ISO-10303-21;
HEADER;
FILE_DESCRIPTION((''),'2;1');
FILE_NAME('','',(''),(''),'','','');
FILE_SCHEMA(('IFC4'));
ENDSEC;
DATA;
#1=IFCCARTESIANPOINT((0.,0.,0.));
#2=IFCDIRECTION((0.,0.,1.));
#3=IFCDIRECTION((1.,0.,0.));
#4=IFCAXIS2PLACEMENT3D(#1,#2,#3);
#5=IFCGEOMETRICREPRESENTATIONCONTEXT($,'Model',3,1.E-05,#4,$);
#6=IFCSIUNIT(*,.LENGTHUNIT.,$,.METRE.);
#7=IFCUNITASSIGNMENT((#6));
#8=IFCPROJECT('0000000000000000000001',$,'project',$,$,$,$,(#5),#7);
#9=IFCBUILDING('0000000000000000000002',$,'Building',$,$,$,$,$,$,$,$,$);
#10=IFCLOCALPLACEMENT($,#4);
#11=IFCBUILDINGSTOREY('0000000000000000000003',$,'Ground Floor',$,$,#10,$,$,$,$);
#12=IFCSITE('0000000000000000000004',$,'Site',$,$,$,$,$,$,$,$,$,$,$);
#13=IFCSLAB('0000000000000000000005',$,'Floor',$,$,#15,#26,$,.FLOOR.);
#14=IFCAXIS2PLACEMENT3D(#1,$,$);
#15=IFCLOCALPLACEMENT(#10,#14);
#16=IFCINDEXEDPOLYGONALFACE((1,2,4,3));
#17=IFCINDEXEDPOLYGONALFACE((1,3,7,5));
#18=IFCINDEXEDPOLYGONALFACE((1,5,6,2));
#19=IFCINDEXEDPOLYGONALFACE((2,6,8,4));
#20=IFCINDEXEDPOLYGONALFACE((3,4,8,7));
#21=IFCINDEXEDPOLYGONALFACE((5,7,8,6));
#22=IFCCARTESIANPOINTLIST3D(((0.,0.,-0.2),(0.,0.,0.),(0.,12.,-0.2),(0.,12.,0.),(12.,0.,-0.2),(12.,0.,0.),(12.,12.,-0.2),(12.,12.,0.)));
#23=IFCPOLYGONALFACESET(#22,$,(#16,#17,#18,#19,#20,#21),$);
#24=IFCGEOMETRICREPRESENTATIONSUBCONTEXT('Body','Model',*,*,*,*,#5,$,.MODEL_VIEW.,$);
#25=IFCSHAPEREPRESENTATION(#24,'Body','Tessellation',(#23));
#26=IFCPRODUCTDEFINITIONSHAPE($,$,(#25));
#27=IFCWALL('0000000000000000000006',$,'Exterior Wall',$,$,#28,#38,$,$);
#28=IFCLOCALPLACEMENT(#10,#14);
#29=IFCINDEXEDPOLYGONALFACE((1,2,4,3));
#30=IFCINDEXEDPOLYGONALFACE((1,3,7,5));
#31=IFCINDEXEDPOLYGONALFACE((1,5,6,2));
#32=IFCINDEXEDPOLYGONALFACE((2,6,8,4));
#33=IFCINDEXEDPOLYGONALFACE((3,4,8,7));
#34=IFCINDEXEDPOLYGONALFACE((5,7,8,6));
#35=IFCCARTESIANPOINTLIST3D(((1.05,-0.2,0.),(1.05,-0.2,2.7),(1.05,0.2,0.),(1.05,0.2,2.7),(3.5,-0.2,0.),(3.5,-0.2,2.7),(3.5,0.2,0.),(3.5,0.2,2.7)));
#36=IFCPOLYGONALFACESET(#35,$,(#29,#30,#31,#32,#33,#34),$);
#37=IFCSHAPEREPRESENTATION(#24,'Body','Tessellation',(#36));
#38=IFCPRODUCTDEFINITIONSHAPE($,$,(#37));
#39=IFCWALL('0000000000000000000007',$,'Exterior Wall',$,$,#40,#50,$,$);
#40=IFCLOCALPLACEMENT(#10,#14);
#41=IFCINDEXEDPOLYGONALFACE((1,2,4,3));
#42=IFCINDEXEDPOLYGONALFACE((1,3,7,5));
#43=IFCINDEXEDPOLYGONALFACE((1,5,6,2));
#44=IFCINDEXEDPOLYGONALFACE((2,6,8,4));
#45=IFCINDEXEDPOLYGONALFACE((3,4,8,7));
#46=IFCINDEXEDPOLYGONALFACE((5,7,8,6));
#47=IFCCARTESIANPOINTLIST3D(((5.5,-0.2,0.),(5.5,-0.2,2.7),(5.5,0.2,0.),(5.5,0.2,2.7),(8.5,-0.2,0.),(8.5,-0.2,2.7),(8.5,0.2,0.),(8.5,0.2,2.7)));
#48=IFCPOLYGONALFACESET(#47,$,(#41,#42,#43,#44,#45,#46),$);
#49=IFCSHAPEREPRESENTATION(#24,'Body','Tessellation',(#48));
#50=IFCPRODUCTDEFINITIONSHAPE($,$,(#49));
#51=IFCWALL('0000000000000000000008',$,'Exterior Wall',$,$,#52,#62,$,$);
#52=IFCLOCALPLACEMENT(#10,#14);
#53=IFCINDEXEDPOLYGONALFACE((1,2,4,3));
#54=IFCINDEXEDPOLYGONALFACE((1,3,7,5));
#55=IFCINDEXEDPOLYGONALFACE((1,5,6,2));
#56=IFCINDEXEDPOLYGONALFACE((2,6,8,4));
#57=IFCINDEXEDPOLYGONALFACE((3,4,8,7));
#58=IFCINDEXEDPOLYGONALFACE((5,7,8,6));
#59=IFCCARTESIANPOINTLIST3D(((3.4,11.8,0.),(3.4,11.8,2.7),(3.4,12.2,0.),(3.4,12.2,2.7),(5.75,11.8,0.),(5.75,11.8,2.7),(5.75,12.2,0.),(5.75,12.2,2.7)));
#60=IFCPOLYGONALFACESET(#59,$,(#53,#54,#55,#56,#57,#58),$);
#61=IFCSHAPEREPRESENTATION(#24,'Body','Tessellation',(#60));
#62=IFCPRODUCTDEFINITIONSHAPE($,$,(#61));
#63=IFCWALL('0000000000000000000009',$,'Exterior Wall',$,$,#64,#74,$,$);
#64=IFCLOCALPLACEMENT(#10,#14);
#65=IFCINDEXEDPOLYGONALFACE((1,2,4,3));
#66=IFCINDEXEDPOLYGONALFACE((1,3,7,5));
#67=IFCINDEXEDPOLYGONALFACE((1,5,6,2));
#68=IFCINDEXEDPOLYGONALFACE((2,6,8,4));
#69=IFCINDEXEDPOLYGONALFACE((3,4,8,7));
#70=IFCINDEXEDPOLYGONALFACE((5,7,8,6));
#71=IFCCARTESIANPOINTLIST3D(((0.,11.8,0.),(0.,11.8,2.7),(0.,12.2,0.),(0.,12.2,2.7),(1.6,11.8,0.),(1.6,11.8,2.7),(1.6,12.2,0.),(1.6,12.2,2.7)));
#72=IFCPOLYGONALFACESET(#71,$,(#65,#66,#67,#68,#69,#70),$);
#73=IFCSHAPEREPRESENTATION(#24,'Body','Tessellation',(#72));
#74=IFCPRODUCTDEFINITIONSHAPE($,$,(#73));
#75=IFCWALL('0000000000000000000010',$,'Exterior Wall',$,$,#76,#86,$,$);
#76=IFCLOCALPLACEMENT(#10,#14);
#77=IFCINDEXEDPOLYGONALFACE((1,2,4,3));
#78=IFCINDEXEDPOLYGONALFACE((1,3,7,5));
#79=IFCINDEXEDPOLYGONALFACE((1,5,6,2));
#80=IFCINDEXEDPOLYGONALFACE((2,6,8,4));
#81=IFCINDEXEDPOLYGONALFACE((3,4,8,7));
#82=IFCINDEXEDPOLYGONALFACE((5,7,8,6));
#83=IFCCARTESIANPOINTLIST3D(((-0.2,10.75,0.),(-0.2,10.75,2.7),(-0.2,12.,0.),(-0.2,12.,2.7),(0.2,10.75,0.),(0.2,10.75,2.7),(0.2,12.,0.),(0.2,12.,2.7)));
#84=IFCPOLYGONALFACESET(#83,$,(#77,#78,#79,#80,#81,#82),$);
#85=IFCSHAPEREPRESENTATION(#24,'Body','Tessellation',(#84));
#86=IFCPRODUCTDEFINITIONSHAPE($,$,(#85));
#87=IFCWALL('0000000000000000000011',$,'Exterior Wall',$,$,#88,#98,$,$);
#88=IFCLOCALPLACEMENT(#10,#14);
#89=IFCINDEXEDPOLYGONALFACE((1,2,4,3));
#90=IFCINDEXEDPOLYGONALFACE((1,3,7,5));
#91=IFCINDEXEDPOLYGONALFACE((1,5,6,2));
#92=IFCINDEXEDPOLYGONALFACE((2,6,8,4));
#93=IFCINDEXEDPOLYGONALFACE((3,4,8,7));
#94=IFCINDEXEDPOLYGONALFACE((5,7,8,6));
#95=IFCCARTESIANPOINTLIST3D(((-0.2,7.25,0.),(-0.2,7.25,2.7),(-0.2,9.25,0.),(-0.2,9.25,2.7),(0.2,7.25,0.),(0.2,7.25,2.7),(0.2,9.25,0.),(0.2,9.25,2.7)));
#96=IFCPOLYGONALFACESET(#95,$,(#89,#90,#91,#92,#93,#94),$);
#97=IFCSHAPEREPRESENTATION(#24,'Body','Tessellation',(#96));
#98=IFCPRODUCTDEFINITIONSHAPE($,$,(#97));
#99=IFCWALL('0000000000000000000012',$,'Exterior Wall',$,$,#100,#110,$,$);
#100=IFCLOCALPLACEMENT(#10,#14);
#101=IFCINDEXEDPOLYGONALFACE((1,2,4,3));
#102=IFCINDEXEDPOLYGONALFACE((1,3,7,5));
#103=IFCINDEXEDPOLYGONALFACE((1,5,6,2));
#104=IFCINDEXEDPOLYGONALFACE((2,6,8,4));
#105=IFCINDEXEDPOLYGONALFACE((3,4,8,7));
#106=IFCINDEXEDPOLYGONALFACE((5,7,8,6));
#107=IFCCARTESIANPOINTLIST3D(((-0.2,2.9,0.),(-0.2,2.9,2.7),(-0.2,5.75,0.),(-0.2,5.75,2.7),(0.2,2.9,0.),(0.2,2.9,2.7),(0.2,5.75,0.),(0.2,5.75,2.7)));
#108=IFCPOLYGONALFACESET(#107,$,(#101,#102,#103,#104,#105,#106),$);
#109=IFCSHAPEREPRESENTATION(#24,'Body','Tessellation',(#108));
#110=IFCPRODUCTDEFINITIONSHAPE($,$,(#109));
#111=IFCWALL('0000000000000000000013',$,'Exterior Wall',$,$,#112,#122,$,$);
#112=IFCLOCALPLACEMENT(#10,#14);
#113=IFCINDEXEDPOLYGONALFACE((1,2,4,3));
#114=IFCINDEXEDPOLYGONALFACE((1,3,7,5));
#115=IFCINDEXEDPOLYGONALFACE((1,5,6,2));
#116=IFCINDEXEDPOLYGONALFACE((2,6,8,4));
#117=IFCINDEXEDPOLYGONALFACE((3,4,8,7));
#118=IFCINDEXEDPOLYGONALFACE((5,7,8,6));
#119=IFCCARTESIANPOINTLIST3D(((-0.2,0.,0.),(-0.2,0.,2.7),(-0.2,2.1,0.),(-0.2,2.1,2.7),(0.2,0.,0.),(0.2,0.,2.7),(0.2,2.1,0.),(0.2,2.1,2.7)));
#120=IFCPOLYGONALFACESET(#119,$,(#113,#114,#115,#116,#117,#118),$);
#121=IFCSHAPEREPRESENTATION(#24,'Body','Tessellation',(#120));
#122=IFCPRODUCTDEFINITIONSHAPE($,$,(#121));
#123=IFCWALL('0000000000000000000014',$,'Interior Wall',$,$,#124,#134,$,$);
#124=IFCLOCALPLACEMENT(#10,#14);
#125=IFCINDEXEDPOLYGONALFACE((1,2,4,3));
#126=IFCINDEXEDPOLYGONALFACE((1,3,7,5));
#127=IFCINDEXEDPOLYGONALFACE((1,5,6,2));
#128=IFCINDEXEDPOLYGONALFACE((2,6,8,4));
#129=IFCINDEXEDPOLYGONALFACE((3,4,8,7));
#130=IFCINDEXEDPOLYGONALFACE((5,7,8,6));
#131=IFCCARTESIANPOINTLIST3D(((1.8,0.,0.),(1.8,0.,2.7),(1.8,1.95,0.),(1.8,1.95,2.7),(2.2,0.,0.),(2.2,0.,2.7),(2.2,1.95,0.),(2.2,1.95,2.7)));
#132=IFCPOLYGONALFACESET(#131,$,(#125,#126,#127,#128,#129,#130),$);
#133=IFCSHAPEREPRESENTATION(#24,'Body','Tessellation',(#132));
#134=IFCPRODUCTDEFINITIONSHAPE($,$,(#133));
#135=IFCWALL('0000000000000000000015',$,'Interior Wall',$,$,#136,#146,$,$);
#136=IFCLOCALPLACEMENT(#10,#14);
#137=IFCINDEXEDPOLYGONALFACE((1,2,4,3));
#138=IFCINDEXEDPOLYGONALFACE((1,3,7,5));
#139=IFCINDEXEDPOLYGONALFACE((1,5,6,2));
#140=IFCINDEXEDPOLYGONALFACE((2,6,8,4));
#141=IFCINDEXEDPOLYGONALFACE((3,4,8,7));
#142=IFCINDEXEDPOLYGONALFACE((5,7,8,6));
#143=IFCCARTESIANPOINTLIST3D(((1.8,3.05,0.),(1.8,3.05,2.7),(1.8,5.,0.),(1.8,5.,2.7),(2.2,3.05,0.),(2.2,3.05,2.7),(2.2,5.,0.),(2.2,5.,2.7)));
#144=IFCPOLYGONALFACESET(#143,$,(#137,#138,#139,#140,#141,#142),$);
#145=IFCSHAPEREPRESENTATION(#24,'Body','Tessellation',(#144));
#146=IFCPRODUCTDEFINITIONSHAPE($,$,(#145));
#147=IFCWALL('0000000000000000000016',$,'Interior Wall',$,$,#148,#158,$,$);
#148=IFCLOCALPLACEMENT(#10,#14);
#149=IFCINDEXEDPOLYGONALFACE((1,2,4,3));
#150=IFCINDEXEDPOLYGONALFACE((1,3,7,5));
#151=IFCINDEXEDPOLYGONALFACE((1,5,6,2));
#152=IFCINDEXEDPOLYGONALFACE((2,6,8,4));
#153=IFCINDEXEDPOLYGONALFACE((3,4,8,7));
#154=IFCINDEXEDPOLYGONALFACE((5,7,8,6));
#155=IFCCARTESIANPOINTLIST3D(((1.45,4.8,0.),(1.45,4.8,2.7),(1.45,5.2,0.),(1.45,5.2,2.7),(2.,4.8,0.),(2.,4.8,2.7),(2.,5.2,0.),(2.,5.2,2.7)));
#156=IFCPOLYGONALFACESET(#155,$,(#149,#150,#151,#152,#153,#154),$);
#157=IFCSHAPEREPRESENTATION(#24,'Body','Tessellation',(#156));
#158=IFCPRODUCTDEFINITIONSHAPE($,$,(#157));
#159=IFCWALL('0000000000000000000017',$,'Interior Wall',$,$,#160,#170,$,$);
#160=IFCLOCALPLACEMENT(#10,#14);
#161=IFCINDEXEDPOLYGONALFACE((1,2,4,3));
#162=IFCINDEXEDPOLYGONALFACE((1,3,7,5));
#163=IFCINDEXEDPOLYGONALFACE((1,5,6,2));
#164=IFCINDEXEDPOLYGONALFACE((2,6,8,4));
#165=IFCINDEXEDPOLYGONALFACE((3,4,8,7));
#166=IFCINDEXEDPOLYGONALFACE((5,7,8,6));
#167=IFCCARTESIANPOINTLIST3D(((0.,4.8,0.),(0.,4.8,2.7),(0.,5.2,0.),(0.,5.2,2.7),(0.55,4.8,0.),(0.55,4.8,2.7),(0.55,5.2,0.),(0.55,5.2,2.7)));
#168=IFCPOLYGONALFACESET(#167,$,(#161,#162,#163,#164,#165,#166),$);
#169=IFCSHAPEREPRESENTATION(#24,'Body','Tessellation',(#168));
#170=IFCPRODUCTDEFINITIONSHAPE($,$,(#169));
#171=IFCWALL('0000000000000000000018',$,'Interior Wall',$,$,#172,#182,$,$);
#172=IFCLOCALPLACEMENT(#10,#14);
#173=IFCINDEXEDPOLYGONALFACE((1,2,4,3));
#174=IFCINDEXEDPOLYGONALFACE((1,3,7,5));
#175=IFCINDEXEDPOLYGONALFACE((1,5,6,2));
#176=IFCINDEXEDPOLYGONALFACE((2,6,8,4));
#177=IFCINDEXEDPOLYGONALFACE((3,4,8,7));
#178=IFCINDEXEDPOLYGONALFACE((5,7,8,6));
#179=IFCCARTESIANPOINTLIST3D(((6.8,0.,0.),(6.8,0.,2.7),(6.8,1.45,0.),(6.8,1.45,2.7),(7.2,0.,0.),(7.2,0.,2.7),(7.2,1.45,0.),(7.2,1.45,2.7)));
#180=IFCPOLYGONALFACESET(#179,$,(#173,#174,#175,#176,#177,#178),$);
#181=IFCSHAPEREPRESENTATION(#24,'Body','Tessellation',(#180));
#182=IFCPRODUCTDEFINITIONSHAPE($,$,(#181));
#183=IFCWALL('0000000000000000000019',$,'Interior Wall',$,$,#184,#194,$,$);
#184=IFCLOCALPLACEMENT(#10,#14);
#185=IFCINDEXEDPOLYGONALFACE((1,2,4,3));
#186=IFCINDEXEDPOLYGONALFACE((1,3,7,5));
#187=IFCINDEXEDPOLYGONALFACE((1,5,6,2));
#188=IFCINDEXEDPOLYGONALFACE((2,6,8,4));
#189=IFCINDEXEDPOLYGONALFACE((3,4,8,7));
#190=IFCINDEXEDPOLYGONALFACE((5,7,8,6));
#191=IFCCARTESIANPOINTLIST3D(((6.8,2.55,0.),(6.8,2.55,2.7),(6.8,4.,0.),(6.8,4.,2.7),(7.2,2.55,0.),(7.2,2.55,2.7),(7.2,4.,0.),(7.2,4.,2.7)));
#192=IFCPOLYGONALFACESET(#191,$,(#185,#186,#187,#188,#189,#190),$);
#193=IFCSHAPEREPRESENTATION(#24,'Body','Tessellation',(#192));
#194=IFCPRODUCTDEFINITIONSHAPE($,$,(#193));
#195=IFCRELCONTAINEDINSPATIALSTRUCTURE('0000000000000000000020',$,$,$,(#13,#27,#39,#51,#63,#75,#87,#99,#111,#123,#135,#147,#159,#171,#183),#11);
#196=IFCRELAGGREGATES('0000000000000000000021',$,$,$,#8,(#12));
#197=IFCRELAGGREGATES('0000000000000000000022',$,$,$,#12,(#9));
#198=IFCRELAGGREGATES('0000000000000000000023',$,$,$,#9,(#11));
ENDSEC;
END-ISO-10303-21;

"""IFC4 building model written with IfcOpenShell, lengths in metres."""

from ifc_helpers import new_model, si_unit, frame, origin_with_axes, place, context, subcontext, project, spatial, indexed_curve, outline, extrude, element, save


model = new_model("IFC4")

# Units and contexts
model_context = context("Model", 3, precision=1e-05, world=origin_with_axes())
body_context = subcontext(model_context, "Body", "Model", "MODEL_VIEW")
ifc_project = project(units=[si_unit("LENGTHUNIT", "METRE")], contexts=[model_context])

# Site, building, storey
site = spatial("IfcSite", under=ifc_project, Name="Site")
building = spatial("IfcBuilding", under=site, Name="Building")
storey_placement = place(None, origin_with_axes())
storey = spatial("IfcBuildingStorey", under=building, at=storey_placement, Name="Ground Floor")

# Slab
slab_placement = place(storey_placement, frame((0.0, 0.0, -0.2), z_axis=(0.0, 0.0, 1.0), x_axis=(1.0, 0.0, 0.0)))
element("IfcSlab", 1, at=slab_placement, inside=storey, Name="Floor", PredefinedType="FLOOR", context=body_context, shape_type="SweptSolid", body=[
    extrude(outline(indexed_curve([(0.0, 0.0), (12.0, 0.0), (12.0, 12.0), (0.0, 12.0)])), None, (0.0, 0.0, 1.0), 0.2),
])

# Walls
wall_1_placement = place(storey_placement, frame((1.05, 0.0, 0.0), z_axis=(0.0, 0.0, 1.0), x_axis=(1.0, 0.0, 0.0)))
element("IfcWall", 2, at=wall_1_placement, inside=storey, Name="Exterior Wall", context=body_context, shape_type="SweptSolid", body=[
    extrude(outline(indexed_curve([(0.0, 0.0), (0.0, 0.4), (2.45, 0.4), (2.45, 0.0), (0.0, 0.0)], self_intersect=False)), frame((0.0, -0.2, 0.0), z_axis=(0.0, 0.0, 1.0), x_axis=(1.0, 0.0, 0.0)), (0.0, 0.0, 1.0), 2.7),
])
wall_2_placement = place(storey_placement, frame((5.5, 0.0, 0.0), z_axis=(0.0, 0.0, 1.0), x_axis=(1.0, 0.0, 0.0)))
element("IfcWall", 3, at=wall_2_placement, inside=storey, Name="Exterior Wall", context=body_context, shape_type="SweptSolid", body=[
    extrude(outline(indexed_curve([(0.0, 0.0), (0.0, 0.4), (3.0, 0.4), (3.0, 0.0), (0.0, 0.0)], self_intersect=False)), frame((0.0, -0.2, 0.0), z_axis=(0.0, 0.0, 1.0), x_axis=(1.0, 0.0, 0.0)), (0.0, 0.0, 1.0), 2.7),
])
wall_3_placement = place(storey_placement, frame((5.75, 12.0, 0.0), z_axis=(0.0, 0.0, 1.0), x_axis=(-1.0, 0.0, 0.0)))
element("IfcWall", 4, at=wall_3_placement, inside=storey, Name="Exterior Wall", context=body_context, shape_type="SweptSolid", body=[
    extrude(outline(indexed_curve([(0.0, 0.0), (0.0, 0.4), (2.35, 0.4), (2.35, 0.0), (0.0, 0.0)], self_intersect=False)), frame((0.0, -0.2, 0.0), z_axis=(0.0, 0.0, 1.0), x_axis=(1.0, 0.0, 0.0)), (0.0, 0.0, 1.0), 2.7),
])
wall_4_placement = place(storey_placement, frame((1.6, 12.0, 0.0), z_axis=(0.0, 0.0, 1.0), x_axis=(-1.0, 0.0, 0.0)))
element("IfcWall", 5, at=wall_4_placement, inside=storey, Name="Exterior Wall", context=body_context, shape_type="SweptSolid", body=[
    extrude(outline(indexed_curve([(0.0, 0.0), (0.0, 0.4), (1.6, 0.4), (1.6, 0.0), (0.0, 0.0)], self_intersect=False)), frame((0.0, -0.2, 0.0), z_axis=(0.0, 0.0, 1.0), x_axis=(1.0, 0.0, 0.0)), (0.0, 0.0, 1.0), 2.7),
])
wall_5_placement = place(storey_placement, frame((0.0, 12.0, 0.0), z_axis=(0.0, 0.0, 1.0), x_axis=(0.0, -1.0, 0.0)))
element("IfcWall", 6, at=wall_5_placement, inside=storey, Name="Exterior Wall", context=body_context, shape_type="SweptSolid", body=[
    extrude(outline(indexed_curve([(0.0, 0.0), (0.0, 0.4), (1.25, 0.4), (1.25, 0.0), (0.0, 0.0)], self_intersect=False)), frame((0.0, -0.2, 0.0), z_axis=(0.0, 0.0, 1.0), x_axis=(1.0, 0.0, 0.0)), (0.0, 0.0, 1.0), 2.7),
])
wall_6_placement = place(storey_placement, frame((0.0, 9.25, 0.0), z_axis=(0.0, 0.0, 1.0), x_axis=(0.0, -1.0, 0.0)))
element("IfcWall", 7, at=wall_6_placement, inside=storey, Name="Exterior Wall", context=body_context, shape_type="SweptSolid", body=[
    extrude(outline(indexed_curve([(0.0, 0.0), (0.0, 0.4), (2.0, 0.4), (2.0, 0.0), (0.0, 0.0)], self_intersect=False)), frame((0.0, -0.2, 0.0), z_axis=(0.0, 0.0, 1.0), x_axis=(1.0, 0.0, 0.0)), (0.0, 0.0, 1.0), 2.7),
])
wall_7_placement = place(storey_placement, frame((0.0, 5.75, 0.0), z_axis=(0.0, 0.0, 1.0), x_axis=(0.0, -1.0, 0.0)))
element("IfcWall", 8, at=wall_7_placement, inside=storey, Name="Exterior Wall", context=body_context, shape_type="SweptSolid", body=[
    extrude(outline(indexed_curve([(0.0, 0.0), (0.0, 0.4), (2.85, 0.4), (2.85, 0.0), (0.0, 0.0)], self_intersect=False)), frame((0.0, -0.2, 0.0), z_axis=(0.0, 0.0, 1.0), x_axis=(1.0, 0.0, 0.0)), (0.0, 0.0, 1.0), 2.7),
])
wall_8_placement = place(storey_placement, frame((0.0, 2.1, 0.0), z_axis=(0.0, 0.0, 1.0), x_axis=(0.0, -1.0, 0.0)))
element("IfcWall", 9, at=wall_8_placement, inside=storey, Name="Exterior Wall", context=body_context, shape_type="SweptSolid", body=[
    extrude(outline(indexed_curve([(0.0, 0.0), (0.0, 0.4), (2.1, 0.4), (2.1, 0.0), (0.0, 0.0)], self_intersect=False)), frame((0.0, -0.2, 0.0), z_axis=(0.0, 0.0, 1.0), x_axis=(1.0, 0.0, 0.0)), (0.0, 0.0, 1.0), 2.7),
])
wall_9_placement = place(storey_placement, frame((2.0, 0.0, 0.0), z_axis=(0.0, 0.0, 1.0), x_axis=(0.0, 1.0, 0.0)))
element("IfcWall", 10, at=wall_9_placement, inside=storey, Name="Interior Wall", context=body_context, shape_type="SweptSolid", body=[
    extrude(outline(indexed_curve([(0.0, 0.0), (0.0, 0.4), (1.95, 0.4), (1.95, 0.0), (0.0, 0.0)], self_intersect=False)), frame((0.0, -0.2, 0.0), z_axis=(0.0, 0.0, 1.0), x_axis=(1.0, 0.0, 0.0)), (0.0, 0.0, 1.0), 2.7),
])
wall_10_placement = place(storey_placement, frame((2.0, 3.05, 0.0), z_axis=(0.0, 0.0, 1.0), x_axis=(0.0, 1.0, 0.0)))
element("IfcWall", 11, at=wall_10_placement, inside=storey, Name="Interior Wall", context=body_context, shape_type="SweptSolid", body=[
    extrude(outline(indexed_curve([(0.0, 0.0), (0.0, 0.4), (1.95, 0.4), (1.95, 0.0), (0.0, 0.0)], self_intersect=False)), frame((0.0, -0.2, 0.0), z_axis=(0.0, 0.0, 1.0), x_axis=(1.0, 0.0, 0.0)), (0.0, 0.0, 1.0), 2.7),
])
for number, where, z_axis, x_axis, name in (
    (12, (2.0, 5.0, 0.0), (0.0, 0.0, 1.0), (-1.0, 0.0, 0.0), "Interior Wall"),
    (13, (0.55, 5.0, 0.0), (0.0, 0.0, 1.0), (-1.0, 0.0, 0.0), "Interior Wall"),
):
    element("IfcWall", number, at=place(storey_placement, frame(where, z_axis=z_axis, x_axis=x_axis)), inside=storey, Name=name, context=body_context, shape_type="SweptSolid", body=[
        extrude(outline(indexed_curve([(0.0, 0.0), (0.0, 0.4), (0.55, 0.4), (0.55, 0.0), (0.0, 0.0)], self_intersect=False)), frame((0.0, -0.2, 0.0), z_axis=(0.0, 0.0, 1.0), x_axis=(1.0, 0.0, 0.0)), (0.0, 0.0, 1.0), 2.7),
    ])
wall_11_placement = place(storey_placement, frame((7.0, 0.0, 0.0), z_axis=(0.0, 0.0, 1.0), x_axis=(0.0, 1.0, 0.0)))
element("IfcWall", 14, at=wall_11_placement, inside=storey, Name="Interior Wall", context=body_context, shape_type="SweptSolid", body=[
    extrude(outline(indexed_curve([(0.0, 0.0), (0.0, 0.4), (1.45, 0.4), (1.45, 0.0), (0.0, 0.0)], self_intersect=False)), frame((0.0, -0.2, 0.0), z_axis=(0.0, 0.0, 1.0), x_axis=(1.0, 0.0, 0.0)), (0.0, 0.0, 1.0), 2.7),
])
wall_12_placement = place(storey_placement, frame((7.0, 2.55, 0.0), z_axis=(0.0, 0.0, 1.0), x_axis=(0.0, 1.0, 0.0)))
element("IfcWall", 15, at=wall_12_placement, inside=storey, Name="Interior Wall", context=body_context, shape_type="SweptSolid", body=[
    extrude(outline(indexed_curve([(0.0, 0.0), (0.0, 0.4), (1.45, 0.4), (1.45, 0.0), (0.0, 0.0)], self_intersect=False)), frame((0.0, -0.2, 0.0), z_axis=(0.0, 0.0, 1.0), x_axis=(1.0, 0.0, 0.0)), (0.0, 0.0, 1.0), 2.7),
])

save(model, "model.ifc")
